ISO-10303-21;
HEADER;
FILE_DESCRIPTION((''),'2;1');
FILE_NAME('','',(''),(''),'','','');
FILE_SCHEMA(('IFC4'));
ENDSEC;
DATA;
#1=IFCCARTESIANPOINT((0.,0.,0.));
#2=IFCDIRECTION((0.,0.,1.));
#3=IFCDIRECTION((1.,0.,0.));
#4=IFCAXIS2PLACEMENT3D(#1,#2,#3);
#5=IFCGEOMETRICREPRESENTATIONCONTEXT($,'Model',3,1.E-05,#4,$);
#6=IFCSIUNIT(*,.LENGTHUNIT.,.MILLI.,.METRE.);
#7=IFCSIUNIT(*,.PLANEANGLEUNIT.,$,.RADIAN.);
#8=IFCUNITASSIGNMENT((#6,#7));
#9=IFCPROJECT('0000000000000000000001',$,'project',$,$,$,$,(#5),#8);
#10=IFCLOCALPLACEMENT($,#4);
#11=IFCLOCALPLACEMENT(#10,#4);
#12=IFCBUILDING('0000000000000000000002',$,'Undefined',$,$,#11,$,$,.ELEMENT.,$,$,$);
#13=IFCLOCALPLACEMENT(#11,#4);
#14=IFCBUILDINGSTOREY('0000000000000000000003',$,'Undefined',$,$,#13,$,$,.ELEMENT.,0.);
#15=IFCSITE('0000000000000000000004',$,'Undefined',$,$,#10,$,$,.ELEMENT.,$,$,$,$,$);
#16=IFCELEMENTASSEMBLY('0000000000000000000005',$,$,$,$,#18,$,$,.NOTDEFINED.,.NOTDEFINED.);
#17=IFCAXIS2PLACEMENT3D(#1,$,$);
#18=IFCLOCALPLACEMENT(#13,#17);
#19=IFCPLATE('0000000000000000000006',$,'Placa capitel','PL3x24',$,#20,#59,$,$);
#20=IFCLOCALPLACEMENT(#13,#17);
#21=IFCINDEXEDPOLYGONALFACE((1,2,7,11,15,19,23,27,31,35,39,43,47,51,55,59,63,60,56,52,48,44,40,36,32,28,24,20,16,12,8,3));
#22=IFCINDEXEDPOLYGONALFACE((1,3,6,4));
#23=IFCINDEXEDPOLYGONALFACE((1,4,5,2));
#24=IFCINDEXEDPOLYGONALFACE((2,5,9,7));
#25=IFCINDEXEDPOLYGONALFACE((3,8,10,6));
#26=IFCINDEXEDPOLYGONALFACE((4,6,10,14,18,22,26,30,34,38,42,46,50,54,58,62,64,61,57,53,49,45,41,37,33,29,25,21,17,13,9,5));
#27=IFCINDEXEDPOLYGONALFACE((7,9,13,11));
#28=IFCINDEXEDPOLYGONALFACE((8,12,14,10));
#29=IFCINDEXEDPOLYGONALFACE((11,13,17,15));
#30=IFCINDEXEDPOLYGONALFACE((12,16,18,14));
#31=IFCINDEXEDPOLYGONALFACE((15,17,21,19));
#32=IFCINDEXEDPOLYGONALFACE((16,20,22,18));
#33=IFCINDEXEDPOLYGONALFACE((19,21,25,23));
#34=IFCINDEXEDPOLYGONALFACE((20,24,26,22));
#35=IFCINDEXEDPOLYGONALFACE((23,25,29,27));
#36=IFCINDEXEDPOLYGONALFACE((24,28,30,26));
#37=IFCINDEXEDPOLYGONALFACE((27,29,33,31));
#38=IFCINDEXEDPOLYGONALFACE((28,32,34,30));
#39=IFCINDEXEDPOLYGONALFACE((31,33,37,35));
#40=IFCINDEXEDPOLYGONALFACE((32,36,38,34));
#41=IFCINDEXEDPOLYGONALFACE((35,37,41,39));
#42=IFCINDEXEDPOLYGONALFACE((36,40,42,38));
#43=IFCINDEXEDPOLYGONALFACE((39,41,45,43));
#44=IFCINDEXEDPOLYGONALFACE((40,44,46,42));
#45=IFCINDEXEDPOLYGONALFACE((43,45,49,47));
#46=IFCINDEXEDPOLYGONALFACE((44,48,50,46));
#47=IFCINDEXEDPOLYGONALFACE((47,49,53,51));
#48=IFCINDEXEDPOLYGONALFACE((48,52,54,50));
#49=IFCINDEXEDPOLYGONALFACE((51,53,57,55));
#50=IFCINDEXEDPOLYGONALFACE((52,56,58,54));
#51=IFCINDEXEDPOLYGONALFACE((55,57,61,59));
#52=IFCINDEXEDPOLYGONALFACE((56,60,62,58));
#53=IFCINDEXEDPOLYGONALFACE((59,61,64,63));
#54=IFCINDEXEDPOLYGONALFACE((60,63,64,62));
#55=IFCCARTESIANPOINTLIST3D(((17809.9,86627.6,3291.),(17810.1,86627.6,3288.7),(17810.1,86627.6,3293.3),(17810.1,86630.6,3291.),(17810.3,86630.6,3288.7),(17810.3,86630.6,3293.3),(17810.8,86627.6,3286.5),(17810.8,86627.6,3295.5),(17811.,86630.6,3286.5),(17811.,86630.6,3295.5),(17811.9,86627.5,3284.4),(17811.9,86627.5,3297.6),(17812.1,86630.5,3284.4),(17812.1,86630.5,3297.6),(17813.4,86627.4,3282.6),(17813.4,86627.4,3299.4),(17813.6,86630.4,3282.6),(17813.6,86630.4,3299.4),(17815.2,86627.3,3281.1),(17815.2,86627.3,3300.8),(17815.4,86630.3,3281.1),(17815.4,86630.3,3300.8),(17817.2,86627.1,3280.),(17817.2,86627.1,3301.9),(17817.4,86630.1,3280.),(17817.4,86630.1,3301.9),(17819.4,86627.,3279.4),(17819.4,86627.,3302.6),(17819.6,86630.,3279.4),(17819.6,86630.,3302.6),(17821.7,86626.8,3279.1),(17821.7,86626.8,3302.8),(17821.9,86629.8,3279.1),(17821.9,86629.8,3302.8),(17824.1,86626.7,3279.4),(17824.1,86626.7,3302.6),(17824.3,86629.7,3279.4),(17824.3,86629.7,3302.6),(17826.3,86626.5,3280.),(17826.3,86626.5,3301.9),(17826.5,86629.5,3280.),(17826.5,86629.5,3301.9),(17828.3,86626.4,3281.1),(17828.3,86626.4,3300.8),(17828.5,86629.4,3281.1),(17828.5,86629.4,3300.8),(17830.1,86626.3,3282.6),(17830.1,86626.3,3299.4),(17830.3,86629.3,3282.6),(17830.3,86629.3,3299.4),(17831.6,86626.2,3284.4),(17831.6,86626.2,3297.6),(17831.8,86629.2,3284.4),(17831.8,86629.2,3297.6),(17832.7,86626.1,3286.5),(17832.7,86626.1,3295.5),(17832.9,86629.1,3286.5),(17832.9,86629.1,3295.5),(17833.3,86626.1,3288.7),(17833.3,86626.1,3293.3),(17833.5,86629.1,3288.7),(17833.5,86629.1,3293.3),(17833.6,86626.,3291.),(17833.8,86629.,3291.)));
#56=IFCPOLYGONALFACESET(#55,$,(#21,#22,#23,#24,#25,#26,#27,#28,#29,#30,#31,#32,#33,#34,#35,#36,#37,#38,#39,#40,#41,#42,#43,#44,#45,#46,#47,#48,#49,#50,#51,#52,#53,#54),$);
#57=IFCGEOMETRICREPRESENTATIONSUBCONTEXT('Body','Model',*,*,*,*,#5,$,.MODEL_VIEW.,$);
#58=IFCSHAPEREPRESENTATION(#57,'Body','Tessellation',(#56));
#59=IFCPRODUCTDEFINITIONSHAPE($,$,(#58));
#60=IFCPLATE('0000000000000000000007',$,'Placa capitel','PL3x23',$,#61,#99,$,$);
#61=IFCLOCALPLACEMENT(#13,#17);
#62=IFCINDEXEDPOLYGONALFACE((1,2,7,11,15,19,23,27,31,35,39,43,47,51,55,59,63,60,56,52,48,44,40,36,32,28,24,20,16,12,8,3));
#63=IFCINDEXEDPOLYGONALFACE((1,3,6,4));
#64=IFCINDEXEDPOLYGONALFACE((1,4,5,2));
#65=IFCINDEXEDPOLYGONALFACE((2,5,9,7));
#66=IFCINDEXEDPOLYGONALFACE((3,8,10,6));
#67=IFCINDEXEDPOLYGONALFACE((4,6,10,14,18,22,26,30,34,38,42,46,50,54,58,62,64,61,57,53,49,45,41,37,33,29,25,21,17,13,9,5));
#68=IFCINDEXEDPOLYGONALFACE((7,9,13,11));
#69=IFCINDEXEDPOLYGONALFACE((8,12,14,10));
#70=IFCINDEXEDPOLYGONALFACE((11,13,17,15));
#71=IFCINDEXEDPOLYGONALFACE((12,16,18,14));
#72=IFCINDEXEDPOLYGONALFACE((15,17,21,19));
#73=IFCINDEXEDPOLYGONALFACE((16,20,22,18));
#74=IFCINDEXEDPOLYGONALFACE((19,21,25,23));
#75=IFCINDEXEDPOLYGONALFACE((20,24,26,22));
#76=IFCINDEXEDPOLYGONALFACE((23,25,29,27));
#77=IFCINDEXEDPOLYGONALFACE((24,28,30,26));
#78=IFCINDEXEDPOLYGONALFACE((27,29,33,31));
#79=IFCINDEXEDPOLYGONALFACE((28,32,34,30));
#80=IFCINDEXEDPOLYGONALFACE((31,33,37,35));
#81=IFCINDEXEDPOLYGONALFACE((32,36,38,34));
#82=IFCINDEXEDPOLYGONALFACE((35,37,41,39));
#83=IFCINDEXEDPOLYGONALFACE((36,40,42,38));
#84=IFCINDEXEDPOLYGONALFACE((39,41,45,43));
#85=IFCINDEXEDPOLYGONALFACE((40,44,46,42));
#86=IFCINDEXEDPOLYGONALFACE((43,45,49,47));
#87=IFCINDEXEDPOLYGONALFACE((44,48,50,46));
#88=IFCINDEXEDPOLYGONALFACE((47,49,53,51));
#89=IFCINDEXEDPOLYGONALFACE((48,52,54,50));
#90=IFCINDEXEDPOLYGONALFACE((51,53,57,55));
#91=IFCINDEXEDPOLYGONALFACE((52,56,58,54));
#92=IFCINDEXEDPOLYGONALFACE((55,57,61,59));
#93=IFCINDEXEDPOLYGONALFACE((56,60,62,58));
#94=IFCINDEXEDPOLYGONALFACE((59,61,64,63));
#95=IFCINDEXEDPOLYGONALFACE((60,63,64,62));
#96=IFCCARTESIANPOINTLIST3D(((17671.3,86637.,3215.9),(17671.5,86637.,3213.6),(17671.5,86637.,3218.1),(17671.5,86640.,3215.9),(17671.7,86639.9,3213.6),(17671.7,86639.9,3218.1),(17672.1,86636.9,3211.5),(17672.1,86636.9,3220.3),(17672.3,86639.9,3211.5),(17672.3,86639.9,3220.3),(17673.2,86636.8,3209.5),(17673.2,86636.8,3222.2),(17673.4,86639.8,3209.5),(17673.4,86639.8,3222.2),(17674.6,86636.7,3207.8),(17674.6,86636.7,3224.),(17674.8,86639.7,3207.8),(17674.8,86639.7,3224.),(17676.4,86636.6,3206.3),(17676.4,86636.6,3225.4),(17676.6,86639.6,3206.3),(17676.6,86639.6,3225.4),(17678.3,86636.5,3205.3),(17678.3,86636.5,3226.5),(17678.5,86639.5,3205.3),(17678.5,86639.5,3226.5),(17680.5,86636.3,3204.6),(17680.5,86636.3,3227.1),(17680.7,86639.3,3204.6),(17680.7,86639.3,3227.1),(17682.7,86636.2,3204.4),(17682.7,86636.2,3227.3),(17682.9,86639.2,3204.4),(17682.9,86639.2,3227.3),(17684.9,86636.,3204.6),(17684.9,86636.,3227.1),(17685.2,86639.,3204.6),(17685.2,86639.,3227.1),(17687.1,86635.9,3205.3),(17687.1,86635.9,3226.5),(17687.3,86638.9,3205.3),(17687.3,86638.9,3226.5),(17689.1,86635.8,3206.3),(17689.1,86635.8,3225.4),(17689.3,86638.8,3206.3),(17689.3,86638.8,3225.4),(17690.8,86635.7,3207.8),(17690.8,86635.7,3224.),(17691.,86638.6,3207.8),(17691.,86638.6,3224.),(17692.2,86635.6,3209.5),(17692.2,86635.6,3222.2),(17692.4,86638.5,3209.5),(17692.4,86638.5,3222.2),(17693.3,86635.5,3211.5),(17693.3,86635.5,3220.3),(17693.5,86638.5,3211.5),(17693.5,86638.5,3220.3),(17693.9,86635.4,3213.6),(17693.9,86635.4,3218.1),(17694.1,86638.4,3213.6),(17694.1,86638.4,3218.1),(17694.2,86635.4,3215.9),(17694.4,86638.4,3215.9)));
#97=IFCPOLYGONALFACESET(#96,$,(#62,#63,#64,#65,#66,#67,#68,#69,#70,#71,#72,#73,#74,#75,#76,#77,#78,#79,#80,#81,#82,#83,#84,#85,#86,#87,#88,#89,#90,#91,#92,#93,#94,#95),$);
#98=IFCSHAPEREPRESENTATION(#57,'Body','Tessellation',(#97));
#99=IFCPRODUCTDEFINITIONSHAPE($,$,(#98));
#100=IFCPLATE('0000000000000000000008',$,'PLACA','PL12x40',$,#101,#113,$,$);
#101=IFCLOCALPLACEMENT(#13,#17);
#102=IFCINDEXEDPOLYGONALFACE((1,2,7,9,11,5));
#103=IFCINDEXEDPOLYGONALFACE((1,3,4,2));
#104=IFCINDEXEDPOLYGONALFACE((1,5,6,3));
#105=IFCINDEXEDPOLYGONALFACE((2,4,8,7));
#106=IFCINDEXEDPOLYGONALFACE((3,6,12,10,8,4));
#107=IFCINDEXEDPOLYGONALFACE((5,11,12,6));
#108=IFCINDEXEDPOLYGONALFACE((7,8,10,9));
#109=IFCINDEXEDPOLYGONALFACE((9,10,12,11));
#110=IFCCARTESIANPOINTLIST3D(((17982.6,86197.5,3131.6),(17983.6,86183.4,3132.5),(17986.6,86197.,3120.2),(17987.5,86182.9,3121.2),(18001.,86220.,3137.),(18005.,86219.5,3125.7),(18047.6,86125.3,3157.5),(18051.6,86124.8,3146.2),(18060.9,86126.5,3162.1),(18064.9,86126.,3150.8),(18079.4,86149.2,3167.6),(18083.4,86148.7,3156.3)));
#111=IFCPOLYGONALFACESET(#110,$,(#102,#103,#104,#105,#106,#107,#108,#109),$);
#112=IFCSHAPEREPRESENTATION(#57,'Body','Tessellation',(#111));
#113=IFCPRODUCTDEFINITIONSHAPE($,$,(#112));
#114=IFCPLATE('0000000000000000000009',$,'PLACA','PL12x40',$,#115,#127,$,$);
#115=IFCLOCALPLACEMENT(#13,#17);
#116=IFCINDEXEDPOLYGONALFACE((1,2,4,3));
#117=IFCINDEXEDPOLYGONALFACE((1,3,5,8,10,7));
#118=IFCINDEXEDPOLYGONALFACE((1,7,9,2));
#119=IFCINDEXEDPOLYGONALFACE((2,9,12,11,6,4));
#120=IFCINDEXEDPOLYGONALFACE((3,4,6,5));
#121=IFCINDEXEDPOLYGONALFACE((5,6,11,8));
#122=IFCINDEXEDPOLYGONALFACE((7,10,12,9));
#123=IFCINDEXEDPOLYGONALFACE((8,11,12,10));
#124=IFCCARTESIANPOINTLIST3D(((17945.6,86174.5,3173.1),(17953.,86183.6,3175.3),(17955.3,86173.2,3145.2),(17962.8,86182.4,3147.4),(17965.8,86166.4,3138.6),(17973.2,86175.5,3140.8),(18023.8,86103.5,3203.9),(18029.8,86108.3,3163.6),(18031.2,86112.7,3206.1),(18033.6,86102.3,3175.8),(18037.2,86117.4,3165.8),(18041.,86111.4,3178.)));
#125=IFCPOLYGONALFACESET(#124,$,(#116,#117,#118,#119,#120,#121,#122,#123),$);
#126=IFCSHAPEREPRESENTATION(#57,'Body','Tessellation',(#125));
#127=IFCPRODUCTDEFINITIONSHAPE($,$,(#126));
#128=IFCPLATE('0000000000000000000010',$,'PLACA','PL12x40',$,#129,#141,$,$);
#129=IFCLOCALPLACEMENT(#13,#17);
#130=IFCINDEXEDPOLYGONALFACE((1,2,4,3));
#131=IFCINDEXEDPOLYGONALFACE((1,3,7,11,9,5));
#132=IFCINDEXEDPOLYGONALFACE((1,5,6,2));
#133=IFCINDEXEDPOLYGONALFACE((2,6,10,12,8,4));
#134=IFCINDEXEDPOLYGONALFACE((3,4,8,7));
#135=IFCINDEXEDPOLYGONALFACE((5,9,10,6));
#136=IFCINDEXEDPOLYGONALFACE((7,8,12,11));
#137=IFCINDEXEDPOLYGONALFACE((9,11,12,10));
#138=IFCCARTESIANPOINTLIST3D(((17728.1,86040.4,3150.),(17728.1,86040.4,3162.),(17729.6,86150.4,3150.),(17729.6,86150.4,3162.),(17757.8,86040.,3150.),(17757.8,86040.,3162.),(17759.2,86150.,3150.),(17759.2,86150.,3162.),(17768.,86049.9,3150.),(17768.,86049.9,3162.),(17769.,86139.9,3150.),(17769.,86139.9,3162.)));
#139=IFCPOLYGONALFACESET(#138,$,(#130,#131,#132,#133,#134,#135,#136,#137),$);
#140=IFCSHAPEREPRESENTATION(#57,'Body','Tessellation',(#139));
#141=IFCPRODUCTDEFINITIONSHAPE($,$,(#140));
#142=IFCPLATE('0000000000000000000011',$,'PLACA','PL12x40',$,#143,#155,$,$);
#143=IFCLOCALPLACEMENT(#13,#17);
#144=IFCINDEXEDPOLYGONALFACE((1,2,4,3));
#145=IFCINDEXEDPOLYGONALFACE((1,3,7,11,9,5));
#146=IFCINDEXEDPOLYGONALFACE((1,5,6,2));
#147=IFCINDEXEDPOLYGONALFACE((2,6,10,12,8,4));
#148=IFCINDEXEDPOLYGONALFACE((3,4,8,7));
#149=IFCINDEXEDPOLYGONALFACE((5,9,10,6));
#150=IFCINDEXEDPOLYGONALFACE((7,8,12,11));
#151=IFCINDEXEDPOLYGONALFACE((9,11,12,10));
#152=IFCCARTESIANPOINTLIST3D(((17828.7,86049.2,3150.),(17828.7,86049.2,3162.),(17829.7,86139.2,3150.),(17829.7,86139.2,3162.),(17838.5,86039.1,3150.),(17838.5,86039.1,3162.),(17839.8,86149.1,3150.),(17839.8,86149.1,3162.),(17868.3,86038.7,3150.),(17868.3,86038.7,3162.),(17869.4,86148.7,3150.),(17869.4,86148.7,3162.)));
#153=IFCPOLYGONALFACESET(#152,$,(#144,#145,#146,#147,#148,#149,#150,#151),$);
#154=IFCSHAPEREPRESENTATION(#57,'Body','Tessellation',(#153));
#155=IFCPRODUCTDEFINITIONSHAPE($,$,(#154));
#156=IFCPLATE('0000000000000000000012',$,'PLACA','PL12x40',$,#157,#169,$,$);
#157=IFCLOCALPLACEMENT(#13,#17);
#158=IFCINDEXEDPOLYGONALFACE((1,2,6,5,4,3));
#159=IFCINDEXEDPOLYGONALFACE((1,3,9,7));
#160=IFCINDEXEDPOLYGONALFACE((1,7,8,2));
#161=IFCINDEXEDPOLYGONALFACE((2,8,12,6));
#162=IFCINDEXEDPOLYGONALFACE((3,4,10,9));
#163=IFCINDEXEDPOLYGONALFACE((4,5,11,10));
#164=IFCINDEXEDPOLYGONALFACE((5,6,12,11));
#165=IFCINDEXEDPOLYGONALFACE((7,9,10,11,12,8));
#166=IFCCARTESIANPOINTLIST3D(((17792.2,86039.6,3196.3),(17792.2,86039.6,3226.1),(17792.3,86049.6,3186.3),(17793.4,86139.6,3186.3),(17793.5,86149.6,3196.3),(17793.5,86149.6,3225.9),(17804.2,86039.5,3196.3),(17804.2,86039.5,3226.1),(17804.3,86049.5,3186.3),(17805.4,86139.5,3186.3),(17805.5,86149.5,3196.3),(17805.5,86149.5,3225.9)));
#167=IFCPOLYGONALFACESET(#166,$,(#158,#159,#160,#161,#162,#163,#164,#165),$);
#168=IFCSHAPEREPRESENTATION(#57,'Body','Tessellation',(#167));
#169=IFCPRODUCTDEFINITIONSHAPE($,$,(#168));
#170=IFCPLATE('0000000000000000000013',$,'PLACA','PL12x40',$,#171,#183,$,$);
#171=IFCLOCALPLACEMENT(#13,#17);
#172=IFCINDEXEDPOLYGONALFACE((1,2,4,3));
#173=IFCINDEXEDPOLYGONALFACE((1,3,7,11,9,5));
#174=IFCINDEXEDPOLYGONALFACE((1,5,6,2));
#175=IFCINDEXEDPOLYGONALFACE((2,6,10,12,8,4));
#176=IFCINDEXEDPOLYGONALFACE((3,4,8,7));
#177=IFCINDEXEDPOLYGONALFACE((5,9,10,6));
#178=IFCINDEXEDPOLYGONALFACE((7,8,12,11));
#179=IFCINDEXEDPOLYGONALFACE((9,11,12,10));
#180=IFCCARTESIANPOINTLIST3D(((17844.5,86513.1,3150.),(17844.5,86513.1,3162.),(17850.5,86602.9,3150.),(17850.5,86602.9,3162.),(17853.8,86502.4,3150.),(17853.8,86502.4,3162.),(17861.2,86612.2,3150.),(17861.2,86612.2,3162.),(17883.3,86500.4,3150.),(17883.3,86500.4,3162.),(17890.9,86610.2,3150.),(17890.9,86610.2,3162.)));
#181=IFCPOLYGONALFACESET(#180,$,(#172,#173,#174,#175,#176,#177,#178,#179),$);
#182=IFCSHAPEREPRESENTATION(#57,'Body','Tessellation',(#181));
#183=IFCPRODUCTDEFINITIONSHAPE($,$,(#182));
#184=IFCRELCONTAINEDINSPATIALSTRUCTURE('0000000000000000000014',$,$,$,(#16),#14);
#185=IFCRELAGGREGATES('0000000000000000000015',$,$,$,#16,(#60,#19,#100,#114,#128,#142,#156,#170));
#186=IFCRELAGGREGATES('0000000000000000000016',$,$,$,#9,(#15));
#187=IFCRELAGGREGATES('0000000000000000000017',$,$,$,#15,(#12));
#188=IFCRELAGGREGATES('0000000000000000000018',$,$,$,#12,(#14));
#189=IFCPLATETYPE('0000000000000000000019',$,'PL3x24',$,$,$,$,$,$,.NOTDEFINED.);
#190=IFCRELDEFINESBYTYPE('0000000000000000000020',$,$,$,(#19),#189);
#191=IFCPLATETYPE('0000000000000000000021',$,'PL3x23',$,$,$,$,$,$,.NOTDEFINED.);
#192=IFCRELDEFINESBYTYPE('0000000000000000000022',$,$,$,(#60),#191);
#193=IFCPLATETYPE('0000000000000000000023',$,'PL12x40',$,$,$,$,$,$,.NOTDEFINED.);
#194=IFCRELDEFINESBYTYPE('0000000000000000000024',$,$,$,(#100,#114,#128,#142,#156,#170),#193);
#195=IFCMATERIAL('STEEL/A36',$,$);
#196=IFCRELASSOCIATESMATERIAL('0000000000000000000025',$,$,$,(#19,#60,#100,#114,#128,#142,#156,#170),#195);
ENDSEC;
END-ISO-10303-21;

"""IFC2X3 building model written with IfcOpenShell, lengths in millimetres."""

from ifc_helpers import new_model, si_unit, frame, origin_with_axes, place, context, subcontext, project, spatial, polyline, outline, extrude, material, type_object, element, aggregate, save


model = new_model("IFC2X3")

# Units and contexts
model_context = context("Model", 3, precision=1e-05, world=origin_with_axes())
body_context = subcontext(model_context, "Body", "Model", "MODEL_VIEW")
ifc_project = project(units=[si_unit("LENGTHUNIT", "METRE", prefix="MILLI"), si_unit("PLANEANGLEUNIT", "RADIAN")], contexts=[model_context])

# Site, building, storey
site_placement = place(None, origin_with_axes())
site = spatial("IfcSite", under=ifc_project, at=site_placement, Name="Undefined", CompositionType="ELEMENT")
building_placement = place(site_placement, origin_with_axes())
building = spatial("IfcBuilding", under=site, at=building_placement, Name="Undefined", CompositionType="ELEMENT")
storey_placement = place(building_placement, origin_with_axes())
storey = spatial("IfcBuildingStorey", under=building, at=storey_placement, Name="Undefined", CompositionType="ELEMENT", Elevation=0.0)

# Element assembly, plates
assembly_placement = place(storey_placement, origin_with_axes())
assembly = element("IfcElementAssembly", 1, at=assembly_placement, inside=storey, AssemblyPlace="NOTDEFINED", PredefinedType="NOTDEFINED")
ifc_material_1 = material(Name="STEEL/A36")
plate_type_1 = type_object("IfcPlateType", Name="PL3x24", PredefinedType="NOTDEFINED")
plate_1_placement = place(assembly_placement, frame((17824.2, 86628.2, 3302.6), z_axis=(0.067124, 0.997745, 0.0), x_axis=(0.954782, -0.064234, -0.290285)))
plate_1 = element("IfcPlate", 2, at=plate_1_placement, type_object=plate_type_1, material=ifc_material_1, Name="Placa capitel", Description="PL3x24", context=body_context, shape_type="SweptSolid", body=[
    extrude(outline(polyline([(0.0, 0.0), (2.3, 0.0), (4.6, 0.5), (6.7, 1.3), (8.7, 2.6), (10.3, 4.3), (11.6, 6.2), (12.5, 8.4), (13.0, 10.6), (13.0, 13.0), (12.5, 15.2), (11.6, 17.4), (10.3, 19.3), (8.7, 21.0), (6.7, 22.2), (4.6, 23.1), (2.3, 23.6), (0.0, 23.6), (-2.3, 23.1), (-4.4, 22.2), (-6.4, 21.0), (-8.0, 19.3), (-9.3, 17.4), (-10.2, 15.2), (-10.6, 13.0), (-10.6, 10.6), (-10.2, 8.4), (-9.3, 6.2), (-8.0, 4.3), (-6.4, 2.6), (-4.4, 1.3), (-2.3, 0.5), (0.0, 0.0)])), frame((0.0, 0.0, -1.5), z_axis=(0.0, 0.0, 1.0), x_axis=(1.0, 0.0, 0.0)), (0.0, 0.0, 1.0), 3.0),
])
plate_type_2 = type_object("IfcPlateType", Name="PL3x23", PredefinedType="NOTDEFINED")
plate_2_placement = place(assembly_placement, frame((17685.1, 86637.5, 3227.1), z_axis=(0.067124, 0.997745, 0.0), x_axis=(0.954782, -0.064234, -0.290285)))
plate_2 = element("IfcPlate", 3, at=plate_2_placement, type_object=plate_type_2, material=ifc_material_1, Name="Placa capitel", Description="PL3x23", context=body_context, shape_type="SweptSolid", body=[
    extrude(outline(polyline([(0.0, 0.0), (2.2, 0.0), (4.5, 0.4), (6.5, 1.3), (8.4, 2.5), (10.0, 4.1), (11.2, 6.0), (12.1, 8.1), (12.5, 10.3), (12.5, 12.5), (12.1, 14.7), (11.2, 16.8), (10.0, 18.7), (8.4, 20.3), (6.5, 21.5), (4.5, 22.4), (2.2, 22.8), (0.0, 22.8), (-2.2, 22.4), (-4.3, 21.5), (-6.2, 20.3), (-7.7, 18.7), (-9.0, 16.8), (-9.8, 14.7), (-10.3, 12.5), (-10.3, 10.3), (-9.8, 8.1), (-9.0, 6.0), (-7.7, 4.1), (-6.2, 2.5), (-4.3, 1.3), (-2.2, 0.4), (0.0, 0.0)])), frame((0.0, 0.0, -1.5), z_axis=(0.0, 0.0, 1.0), x_axis=(1.0, 0.0, 0.0)), (0.0, 0.0, 1.0), 3.0),
])
plate_type_3 = type_object("IfcPlateType", Name="PL12x40", PredefinedType="NOTDEFINED")
plate_3_placement = place(assembly_placement, frame((18081.4, 86149.0, 3161.9), z_axis=(0.330461, -0.041741, -0.942896), x_axis=(-0.620011, -0.762826, -0.183528)))
plate_3 = element("IfcPlate", 4, at=plate_3_placement, type_object=plate_type_3, material=ifc_material_1, Name="PLACA", Description="PL12x40", context=body_context, shape_type="SweptSolid", body=[
    extrude(outline(polyline([(0.0, 0.0), (29.8, 0.0), (39.8, 10.0), (39.8, 100.0), (29.8, 110.0), (0.2, 110.0), (0.0, 0.0)])), frame((0.0, 0.0, -6.0), z_axis=(0.0, 0.0, 1.0), x_axis=(1.0, 0.0, 0.0)), (0.0, 0.0, 1.0), 12.0),
])
plate_4_placement = place(assembly_placement, frame((18027.5, 86108.1, 3205.0), z_axis=(0.620011, 0.762826, 0.183528), x_axis=(0.330461, -0.041741, -0.942896)))
plate_4 = element("IfcPlate", 5, at=plate_4_placement, type_object=plate_type_3, material=ifc_material_1, Name="PLACA", Description="PL12x40", context=body_context, shape_type="SweptSolid", body=[
    extrude(outline(polyline([(0.0, 0.0), (29.8, 0.0), (39.8, 10.0), (39.8, 100.0), (29.8, 110.0), (0.2, 110.0), (0.0, 0.0)])), frame((0.0, 0.0, -6.0), z_axis=(0.0, 0.0, 1.0), x_axis=(1.0, 0.0, 0.0)), (0.0, 0.0, 1.0), 12.0),
])
plate_5_placement = place(assembly_placement, frame((17728.1, 86040.4, 3156.0), z_axis=(0.0, 0.0, 1.0), x_axis=(0.99993, -0.011839, 0.0)))
plate_5 = element("IfcPlate", 6, at=plate_5_placement, type_object=plate_type_3, material=ifc_material_1, Name="PLACA", Description="PL12x40", context=body_context, shape_type="SweptSolid", body=[
    extrude(outline(polyline([(0.0, 0.0), (29.8, 0.0), (39.8, 10.0), (39.8, 100.0), (29.8, 110.0), (0.2, 110.0), (0.0, 0.0)])), frame((0.0, 0.0, -6.0), z_axis=(0.0, 0.0, 1.0), x_axis=(1.0, 0.0, 0.0)), (0.0, 0.0, 1.0), 12.0),
])
plate_6_placement = place(assembly_placement, frame((17868.3, 86038.7, 3156.0), z_axis=(0.0, 0.0, -1.0), x_axis=(-0.99993, 0.011839, 0.0)))
plate_6 = element("IfcPlate", 7, at=plate_6_placement, type_object=plate_type_3, material=ifc_material_1, Name="PLACA", Description="PL12x40", context=body_context, shape_type="SweptSolid", body=[
    extrude(outline(polyline([(0.0, 0.0), (29.8, 0.0), (39.8, 10.0), (39.8, 100.0), (29.8, 110.0), (0.2, 110.0), (0.0, 0.0)])), frame((0.0, 0.0, -6.0), z_axis=(0.0, 0.0, 1.0), x_axis=(1.0, 0.0, 0.0)), (0.0, 0.0, 1.0), 12.0),
])
plate_7_placement = place(assembly_placement, frame((17798.2, 86039.5, 3226.1), z_axis=(0.99993, -0.011839, 0.0), x_axis=(0.0, 0.0, -1.0)))
plate_7 = element("IfcPlate", 8, at=plate_7_placement, type_object=plate_type_3, material=ifc_material_1, Name="PLACA", Description="PL12x40", context=body_context, shape_type="SweptSolid", body=[
    extrude(outline(polyline([(0.0, 0.0), (29.8, 0.0), (39.8, 10.0), (39.8, 100.0), (29.8, 110.0), (0.2, 110.0), (0.0, 0.0)])), frame((0.0, 0.0, -6.0), z_axis=(0.0, 0.0, 1.0), x_axis=(1.0, 0.0, 0.0)), (0.0, 0.0, 1.0), 12.0),
])
plate_8_placement = place(assembly_placement, frame((17890.9, 86610.2, 3156.0), z_axis=(0.0, 0.0, 1.0), x_axis=(-0.997745, 0.067123, 0.0)))
plate_8 = element("IfcPlate", 9, at=plate_8_placement, type_object=plate_type_3, material=ifc_material_1, Name="PLACA", Description="PL12x40", context=body_context, shape_type="SweptSolid", body=[
    extrude(outline(polyline([(0.0, 0.0), (29.8, 0.0), (39.8, 10.0), (39.8, 100.0), (29.8, 110.0), (0.2, 110.0), (0.0, 0.0)])), frame((0.0, 0.0, -6.0), z_axis=(0.0, 0.0, 1.0), x_axis=(1.0, 0.0, 0.0)), (0.0, 0.0, 1.0), 12.0),
])
aggregate(assembly, [plate_2, plate_1, plate_3, plate_4, plate_5, plate_6, plate_7, plate_8])

save(model, "model.ifc")
